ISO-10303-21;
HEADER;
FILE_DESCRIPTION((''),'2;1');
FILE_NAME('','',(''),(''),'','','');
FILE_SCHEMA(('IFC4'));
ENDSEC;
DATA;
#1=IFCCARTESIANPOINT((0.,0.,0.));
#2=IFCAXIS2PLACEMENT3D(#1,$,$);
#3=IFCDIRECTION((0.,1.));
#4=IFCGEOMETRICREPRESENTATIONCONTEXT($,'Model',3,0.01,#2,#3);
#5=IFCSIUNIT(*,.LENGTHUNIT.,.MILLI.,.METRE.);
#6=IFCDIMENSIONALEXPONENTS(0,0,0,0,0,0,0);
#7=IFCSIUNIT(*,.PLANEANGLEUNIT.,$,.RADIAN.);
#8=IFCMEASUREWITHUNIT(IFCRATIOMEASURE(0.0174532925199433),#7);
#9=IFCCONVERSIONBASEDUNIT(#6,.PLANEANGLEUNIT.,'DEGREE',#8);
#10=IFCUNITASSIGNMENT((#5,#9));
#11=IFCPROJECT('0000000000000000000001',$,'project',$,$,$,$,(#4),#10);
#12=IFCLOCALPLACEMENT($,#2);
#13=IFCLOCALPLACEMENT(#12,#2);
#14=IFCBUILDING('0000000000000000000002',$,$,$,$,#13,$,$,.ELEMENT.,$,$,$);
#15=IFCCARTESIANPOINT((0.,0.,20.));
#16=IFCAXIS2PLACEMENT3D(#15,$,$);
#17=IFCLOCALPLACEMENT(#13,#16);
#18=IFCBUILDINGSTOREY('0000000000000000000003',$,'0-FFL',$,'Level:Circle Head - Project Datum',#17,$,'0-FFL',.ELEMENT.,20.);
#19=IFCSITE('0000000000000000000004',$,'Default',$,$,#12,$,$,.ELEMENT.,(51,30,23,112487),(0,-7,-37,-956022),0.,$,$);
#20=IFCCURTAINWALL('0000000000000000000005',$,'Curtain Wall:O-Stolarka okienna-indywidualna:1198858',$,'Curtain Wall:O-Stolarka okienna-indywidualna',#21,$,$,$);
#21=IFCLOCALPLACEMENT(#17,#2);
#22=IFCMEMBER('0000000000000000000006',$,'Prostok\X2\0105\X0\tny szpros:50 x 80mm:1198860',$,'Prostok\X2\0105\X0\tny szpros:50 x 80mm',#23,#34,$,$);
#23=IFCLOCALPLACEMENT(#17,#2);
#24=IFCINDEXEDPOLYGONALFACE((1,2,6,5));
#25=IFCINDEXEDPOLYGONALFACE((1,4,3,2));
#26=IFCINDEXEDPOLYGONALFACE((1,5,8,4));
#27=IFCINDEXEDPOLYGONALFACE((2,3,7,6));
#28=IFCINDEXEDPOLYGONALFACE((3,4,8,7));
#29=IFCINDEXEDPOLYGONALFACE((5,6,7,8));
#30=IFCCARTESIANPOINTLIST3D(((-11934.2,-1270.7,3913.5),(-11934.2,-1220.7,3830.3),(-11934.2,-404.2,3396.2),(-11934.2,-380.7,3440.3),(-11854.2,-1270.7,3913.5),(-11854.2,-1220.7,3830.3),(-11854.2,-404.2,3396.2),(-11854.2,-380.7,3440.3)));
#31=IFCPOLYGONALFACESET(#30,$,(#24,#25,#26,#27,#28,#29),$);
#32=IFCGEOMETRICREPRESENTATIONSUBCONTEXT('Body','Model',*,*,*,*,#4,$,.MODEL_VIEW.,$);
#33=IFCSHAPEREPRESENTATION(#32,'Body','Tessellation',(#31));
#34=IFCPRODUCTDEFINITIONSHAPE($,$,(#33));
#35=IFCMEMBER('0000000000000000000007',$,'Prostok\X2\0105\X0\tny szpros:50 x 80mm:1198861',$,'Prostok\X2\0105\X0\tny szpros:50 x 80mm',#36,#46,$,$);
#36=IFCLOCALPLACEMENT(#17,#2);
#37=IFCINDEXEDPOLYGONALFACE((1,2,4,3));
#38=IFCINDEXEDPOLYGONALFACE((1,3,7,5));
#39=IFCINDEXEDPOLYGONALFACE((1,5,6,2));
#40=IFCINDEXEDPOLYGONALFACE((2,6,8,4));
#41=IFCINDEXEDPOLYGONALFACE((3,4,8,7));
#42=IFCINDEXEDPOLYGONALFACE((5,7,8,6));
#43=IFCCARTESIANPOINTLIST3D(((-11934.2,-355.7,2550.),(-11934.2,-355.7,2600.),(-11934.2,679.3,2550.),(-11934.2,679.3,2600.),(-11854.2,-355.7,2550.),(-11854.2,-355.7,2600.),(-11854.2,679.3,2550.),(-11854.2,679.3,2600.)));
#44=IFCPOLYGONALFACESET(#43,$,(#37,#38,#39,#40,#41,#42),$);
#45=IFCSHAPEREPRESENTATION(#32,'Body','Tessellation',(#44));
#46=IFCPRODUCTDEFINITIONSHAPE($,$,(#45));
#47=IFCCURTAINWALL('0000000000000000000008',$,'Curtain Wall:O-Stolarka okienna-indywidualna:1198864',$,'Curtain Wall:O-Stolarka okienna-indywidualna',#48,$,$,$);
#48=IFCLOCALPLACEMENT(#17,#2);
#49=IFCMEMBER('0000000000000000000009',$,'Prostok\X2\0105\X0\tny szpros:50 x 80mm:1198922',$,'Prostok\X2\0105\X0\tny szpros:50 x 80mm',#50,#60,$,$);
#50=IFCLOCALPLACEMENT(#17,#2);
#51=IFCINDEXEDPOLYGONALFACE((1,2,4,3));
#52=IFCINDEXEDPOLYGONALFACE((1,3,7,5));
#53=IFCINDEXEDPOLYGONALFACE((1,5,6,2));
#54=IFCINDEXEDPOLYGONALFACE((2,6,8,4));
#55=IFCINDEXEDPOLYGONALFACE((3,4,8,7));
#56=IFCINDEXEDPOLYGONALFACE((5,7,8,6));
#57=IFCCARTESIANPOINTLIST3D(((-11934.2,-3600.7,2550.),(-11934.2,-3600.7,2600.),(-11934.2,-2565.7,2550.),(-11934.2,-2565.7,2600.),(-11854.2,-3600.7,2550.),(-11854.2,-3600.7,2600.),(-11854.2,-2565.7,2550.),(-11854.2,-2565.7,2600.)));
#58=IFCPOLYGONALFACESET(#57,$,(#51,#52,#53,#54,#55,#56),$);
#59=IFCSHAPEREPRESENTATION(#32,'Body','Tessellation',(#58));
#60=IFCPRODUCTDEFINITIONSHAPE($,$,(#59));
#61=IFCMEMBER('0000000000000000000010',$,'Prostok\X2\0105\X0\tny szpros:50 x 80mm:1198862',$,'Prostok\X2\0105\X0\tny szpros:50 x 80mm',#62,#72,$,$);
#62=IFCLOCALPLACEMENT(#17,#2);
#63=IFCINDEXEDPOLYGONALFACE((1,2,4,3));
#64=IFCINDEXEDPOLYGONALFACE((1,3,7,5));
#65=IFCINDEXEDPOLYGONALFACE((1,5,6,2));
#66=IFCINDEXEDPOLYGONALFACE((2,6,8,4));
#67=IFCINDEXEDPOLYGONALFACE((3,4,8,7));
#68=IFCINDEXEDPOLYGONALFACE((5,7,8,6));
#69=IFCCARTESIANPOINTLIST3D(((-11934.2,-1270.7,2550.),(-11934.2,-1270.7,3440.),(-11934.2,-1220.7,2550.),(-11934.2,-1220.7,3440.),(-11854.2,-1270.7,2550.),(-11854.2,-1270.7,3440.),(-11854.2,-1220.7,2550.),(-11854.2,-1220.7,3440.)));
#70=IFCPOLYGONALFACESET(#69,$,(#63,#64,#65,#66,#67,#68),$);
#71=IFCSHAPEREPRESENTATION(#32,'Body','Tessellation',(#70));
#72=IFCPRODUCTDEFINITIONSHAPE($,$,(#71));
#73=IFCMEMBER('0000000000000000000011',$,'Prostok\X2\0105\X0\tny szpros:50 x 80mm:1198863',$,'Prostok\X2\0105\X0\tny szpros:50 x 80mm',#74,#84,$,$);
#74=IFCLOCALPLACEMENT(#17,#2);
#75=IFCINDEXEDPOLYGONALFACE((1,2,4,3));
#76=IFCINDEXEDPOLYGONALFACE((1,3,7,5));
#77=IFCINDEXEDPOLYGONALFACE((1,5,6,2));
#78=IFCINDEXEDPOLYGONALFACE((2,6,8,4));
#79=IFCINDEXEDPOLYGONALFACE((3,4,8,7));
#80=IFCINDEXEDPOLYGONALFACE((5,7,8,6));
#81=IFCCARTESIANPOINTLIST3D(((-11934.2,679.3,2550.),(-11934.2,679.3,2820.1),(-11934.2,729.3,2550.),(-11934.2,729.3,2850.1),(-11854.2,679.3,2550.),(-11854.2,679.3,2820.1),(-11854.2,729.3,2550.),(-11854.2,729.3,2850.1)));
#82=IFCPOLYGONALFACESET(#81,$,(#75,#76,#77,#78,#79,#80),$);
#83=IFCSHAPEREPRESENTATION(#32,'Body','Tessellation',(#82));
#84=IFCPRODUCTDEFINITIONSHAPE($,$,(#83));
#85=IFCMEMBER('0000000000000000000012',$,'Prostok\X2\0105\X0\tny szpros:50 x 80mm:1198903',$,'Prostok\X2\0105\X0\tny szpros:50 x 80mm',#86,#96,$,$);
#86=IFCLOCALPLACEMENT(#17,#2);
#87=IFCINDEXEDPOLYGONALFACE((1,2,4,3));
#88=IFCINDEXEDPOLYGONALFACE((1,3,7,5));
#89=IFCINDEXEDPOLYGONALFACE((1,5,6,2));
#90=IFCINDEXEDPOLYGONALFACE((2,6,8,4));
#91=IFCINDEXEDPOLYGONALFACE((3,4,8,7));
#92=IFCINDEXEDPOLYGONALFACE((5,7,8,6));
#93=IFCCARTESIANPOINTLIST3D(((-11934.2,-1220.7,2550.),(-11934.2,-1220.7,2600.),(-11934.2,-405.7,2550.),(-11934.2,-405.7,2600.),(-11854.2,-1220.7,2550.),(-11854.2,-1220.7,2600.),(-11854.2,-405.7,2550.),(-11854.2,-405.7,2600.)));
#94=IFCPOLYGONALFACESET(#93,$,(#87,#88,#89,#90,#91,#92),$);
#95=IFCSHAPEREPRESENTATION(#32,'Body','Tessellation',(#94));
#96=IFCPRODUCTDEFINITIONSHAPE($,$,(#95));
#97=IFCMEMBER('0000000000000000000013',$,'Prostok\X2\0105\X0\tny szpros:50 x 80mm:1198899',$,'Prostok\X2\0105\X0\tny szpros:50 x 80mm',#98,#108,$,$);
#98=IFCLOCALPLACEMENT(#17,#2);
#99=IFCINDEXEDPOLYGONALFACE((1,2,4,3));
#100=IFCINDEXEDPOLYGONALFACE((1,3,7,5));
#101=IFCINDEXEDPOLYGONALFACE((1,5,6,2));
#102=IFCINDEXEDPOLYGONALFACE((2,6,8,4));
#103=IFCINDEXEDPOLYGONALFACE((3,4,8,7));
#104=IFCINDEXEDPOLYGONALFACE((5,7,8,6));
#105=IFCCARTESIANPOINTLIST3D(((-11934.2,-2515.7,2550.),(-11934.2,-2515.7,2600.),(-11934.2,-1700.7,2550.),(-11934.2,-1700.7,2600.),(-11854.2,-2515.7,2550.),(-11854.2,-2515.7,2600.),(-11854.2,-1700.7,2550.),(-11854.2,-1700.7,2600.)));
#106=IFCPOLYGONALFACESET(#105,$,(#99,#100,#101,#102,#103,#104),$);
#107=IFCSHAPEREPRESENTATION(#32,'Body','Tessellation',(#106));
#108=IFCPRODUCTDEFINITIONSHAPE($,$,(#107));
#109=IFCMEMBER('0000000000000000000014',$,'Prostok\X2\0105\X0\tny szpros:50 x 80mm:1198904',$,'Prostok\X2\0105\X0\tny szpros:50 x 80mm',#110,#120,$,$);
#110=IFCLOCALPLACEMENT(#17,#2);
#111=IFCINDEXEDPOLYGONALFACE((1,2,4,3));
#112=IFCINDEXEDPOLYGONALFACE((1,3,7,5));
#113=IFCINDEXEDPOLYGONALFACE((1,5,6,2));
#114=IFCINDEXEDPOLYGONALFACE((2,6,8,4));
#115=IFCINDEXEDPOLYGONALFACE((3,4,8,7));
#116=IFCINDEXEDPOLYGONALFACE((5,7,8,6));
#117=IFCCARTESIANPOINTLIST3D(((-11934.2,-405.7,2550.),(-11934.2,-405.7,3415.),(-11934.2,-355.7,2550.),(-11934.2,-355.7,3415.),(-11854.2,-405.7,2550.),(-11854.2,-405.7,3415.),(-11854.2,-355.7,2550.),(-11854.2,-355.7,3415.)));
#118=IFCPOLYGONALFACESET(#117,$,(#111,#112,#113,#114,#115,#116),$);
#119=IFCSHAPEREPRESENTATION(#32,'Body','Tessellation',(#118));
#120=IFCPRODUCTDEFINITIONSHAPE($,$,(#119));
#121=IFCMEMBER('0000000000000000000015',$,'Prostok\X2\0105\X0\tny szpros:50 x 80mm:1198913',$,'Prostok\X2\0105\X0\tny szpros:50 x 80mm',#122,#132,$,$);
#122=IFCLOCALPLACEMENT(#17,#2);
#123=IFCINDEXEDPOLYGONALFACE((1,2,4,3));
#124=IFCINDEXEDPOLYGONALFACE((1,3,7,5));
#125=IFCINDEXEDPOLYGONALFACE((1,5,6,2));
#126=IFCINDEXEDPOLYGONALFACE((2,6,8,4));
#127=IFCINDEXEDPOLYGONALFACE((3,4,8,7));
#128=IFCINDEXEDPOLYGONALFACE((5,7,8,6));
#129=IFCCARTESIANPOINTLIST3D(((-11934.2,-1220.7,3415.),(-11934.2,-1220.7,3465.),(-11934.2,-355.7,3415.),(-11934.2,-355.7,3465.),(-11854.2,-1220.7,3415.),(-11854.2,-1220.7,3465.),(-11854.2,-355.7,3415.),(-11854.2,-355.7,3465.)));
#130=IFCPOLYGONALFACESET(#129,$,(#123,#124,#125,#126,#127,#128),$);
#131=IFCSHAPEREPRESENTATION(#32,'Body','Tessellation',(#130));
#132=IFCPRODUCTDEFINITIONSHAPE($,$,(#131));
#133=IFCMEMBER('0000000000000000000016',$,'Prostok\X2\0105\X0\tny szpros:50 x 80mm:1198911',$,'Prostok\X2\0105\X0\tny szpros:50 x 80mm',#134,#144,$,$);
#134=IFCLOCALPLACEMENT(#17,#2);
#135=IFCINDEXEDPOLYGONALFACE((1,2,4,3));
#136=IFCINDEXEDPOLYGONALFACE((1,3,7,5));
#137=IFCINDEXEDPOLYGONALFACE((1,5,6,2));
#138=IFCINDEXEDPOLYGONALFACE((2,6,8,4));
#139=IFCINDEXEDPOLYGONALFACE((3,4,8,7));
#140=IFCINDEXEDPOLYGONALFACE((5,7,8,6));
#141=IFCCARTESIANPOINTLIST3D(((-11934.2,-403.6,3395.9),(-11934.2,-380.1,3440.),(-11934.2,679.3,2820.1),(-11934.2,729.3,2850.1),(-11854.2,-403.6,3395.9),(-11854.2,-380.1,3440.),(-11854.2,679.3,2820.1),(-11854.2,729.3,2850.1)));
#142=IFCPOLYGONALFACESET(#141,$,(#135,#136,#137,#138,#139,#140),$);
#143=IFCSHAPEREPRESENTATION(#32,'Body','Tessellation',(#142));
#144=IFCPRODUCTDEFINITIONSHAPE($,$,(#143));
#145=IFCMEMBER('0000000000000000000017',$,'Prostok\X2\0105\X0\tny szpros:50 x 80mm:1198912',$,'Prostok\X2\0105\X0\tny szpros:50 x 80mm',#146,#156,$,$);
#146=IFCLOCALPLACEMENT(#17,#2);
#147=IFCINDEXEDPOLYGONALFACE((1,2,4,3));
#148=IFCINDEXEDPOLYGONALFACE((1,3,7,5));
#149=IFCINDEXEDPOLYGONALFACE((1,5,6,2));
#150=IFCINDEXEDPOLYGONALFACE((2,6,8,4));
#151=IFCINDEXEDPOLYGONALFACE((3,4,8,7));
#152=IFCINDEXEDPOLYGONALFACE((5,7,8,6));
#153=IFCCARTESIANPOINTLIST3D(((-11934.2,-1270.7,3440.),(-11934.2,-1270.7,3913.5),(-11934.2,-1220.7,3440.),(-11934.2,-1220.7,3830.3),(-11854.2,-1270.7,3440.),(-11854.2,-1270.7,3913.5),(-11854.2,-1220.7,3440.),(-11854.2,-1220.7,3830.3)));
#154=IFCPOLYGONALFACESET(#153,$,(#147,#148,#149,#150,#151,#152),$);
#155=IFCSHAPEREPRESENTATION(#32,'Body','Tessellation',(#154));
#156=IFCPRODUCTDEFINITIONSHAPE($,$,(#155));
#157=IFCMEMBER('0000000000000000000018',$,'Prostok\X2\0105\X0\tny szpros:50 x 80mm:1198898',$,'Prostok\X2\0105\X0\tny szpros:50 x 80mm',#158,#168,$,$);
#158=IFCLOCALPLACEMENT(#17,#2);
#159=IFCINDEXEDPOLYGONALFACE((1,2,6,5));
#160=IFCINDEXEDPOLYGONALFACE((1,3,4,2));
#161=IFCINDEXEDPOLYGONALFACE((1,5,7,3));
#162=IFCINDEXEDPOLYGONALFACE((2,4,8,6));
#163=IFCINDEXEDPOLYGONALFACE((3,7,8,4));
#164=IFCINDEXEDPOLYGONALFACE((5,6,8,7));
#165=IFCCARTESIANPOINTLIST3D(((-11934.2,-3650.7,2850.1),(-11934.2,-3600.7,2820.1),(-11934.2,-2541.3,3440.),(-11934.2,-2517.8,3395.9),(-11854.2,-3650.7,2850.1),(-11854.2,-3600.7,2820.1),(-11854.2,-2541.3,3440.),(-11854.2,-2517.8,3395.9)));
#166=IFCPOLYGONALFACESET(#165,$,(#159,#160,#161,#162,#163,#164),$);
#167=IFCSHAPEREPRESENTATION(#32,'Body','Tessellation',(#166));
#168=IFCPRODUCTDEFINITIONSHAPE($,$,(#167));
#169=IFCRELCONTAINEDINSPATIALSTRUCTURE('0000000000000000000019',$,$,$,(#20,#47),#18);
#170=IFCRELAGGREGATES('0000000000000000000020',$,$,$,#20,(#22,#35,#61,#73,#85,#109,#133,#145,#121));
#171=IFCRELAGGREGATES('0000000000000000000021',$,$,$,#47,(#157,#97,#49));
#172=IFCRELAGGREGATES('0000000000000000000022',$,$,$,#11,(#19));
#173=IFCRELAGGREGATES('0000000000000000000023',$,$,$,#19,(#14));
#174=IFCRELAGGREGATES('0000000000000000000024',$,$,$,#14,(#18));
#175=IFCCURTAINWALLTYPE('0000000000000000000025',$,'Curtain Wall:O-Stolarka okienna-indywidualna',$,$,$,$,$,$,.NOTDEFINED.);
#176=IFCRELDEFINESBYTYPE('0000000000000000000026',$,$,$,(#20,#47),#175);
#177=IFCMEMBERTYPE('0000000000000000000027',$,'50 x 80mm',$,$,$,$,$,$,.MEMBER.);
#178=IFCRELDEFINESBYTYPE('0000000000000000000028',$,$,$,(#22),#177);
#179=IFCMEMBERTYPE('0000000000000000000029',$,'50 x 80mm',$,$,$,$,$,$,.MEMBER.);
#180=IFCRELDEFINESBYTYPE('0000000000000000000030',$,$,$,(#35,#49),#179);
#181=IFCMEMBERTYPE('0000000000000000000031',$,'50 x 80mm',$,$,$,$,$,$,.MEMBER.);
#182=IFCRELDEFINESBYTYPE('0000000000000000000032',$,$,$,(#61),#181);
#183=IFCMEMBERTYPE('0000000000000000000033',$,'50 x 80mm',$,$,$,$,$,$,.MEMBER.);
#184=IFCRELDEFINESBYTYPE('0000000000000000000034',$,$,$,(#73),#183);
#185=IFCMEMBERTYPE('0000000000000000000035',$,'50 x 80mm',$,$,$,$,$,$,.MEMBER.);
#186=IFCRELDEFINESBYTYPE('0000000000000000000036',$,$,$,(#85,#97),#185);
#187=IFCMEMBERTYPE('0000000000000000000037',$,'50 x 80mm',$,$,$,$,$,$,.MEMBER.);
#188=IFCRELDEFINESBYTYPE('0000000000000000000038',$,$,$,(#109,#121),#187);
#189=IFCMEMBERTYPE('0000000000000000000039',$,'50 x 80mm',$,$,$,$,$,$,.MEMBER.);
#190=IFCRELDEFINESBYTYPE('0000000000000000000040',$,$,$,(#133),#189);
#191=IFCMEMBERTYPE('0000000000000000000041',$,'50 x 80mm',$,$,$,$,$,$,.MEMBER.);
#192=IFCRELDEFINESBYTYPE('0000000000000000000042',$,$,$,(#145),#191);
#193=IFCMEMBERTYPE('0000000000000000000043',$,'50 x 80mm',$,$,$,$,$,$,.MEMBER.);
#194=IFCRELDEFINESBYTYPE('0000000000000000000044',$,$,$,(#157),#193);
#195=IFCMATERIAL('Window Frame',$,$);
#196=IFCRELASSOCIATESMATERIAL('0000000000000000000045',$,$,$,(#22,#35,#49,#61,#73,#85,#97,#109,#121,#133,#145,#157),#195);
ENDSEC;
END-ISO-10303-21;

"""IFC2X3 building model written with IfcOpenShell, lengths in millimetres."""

from ifc_helpers import new_model, entity, si_unit, converted_unit, direction, frame, origin, origin_2d_with_axis, place, context, subcontext, project, spatial, rectangle, extrude, clip, halfspace, source, transform, mapped, material, type_object, type_shapes, element, aggregate, save


model = new_model("IFC2X3")

# Units and contexts
model_context = context("Model", 3, precision=0.01, world=origin(), true_north=direction((0.0, 1.0)))
body_context = subcontext(model_context, "Body", "Model", "MODEL_VIEW")
ifc_project = project(units=[si_unit("LENGTHUNIT", "METRE", prefix="MILLI"), converted_unit("PLANEANGLEUNIT", "DEGREE", entity("IfcRatioMeasure", 0.0174532925199433), si_unit("PLANEANGLEUNIT", "RADIAN"), dimensions=[0, 0, 0, 0, 0, 0, 0])], contexts=[model_context])

# Site, building, storey
site_placement = place(None, origin())
site = spatial("IfcSite", under=ifc_project, at=site_placement, Name="Default", CompositionType="ELEMENT", RefLatitude=(51, 30, 23, 112487), RefLongitude=(0, -7, -37, -956022), RefElevation=0.0)
building_placement = place(site_placement, origin())
building = spatial("IfcBuilding", under=site, at=building_placement, CompositionType="ELEMENT")
storey_placement = place(building_placement, frame((0.0, 0.0, 20.0)))
storey = spatial("IfcBuildingStorey", under=building, at=storey_placement, Name="0-FFL", ObjectType="Level:Circle Head - Project Datum", LongName="0-FFL", CompositionType="ELEMENT", Elevation=20.0)

# Curtain wall, members
curtain_wall_type = type_object("IfcCurtainWallType", Name="Curtain Wall:O-Stolarka okienna-indywidualna", PredefinedType="NOTDEFINED")
curtain_wall_1_placement = place(storey_placement, frame((0.0, 0.0, -20.0)))
curtain_wall_1 = element("IfcCurtainWall", 1, at=curtain_wall_1_placement, inside=storey, type_object=curtain_wall_type, Name="Curtain Wall:O-Stolarka okienna-indywidualna:1198858", ObjectType="Curtain Wall:O-Stolarka okienna-indywidualna")
ifc_material_1 = material(Name="Window Frame")
member_type_1 = type_object("IfcMemberType", Name="50 x 80mm", PredefinedType="MEMBER")
shared_shape_1 = source(origin(), body_context, "Body", "Clipping", [
    clip(extrude(rectangle(XDim=80.0, YDim=50.0, at=origin_2d_with_axis()), frame((-25.0, 0.0, -1008.0), z_axis=(0.0, 0.0, 1.0), x_axis=(0.0, -1.0, 0.0)), (0.0, 0.0, 1.0), 1008.0), halfspace(frame((0.0, -304.8, 0.0), z_axis=(-0.857167, 0.0, 0.515038), x_axis=(-0.515038, 0.0, -0.857167)), False)),
])
type_shapes(member_type_1, [shared_shape_1])
placement = place(building_placement, origin())
member_1_placement = place(placement, frame((-11894.2, -1270.7, 3933.5), z_axis=(0.0, -0.882948, 0.469472), x_axis=(0.0, 0.469472, 0.882948)))
member_1 = element("IfcMember", 2, at=member_1_placement, type_object=member_type_1, material=ifc_material_1, Name="Prostokątny szpros:50 x 80mm:1198860", ObjectType="Prostokątny szpros:50 x 80mm", context=body_context, shape_type="MappedRepresentation", body=[
    mapped(shared_shape_1, transform((0.0, 0.0, 0.0), scale=1.0)),
])
member_type_2 = type_object("IfcMemberType", Name="50 x 80mm", PredefinedType="MEMBER")
shared_shape_2 = source(origin(), body_context, "Body", "SweptSolid", [
    extrude(rectangle(XDim=80.0, YDim=50.0, at=origin_2d_with_axis()), frame((-25.0, 0.0, -1035.0), z_axis=(0.0, 0.0, 1.0), x_axis=(0.0, -1.0, 0.0)), (0.0, 0.0, 1.0), 1035.0),
])
type_shapes(member_type_2, [shared_shape_2])
member_2_placement = place(placement, frame((-11894.2, 679.3, 2570.0), z_axis=(0.0, 1.0, 0.0), x_axis=(0.0, 0.0, -1.0)))
member_2 = element("IfcMember", 3, at=member_2_placement, type_object=member_type_2, material=ifc_material_1, Name="Prostokątny szpros:50 x 80mm:1198861", ObjectType="Prostokątny szpros:50 x 80mm", context=body_context, shape_type="MappedRepresentation", body=[
    mapped(shared_shape_2, transform((0.0, 0.0, 0.0), scale=1.0)),
])

# Curtain wall, member
curtain_wall_2_placement = place(storey_placement, frame((0.0, 0.0, -20.0)))
curtain_wall_2 = element("IfcCurtainWall", 4, at=curtain_wall_2_placement, inside=storey, type_object=curtain_wall_type, Name="Curtain Wall:O-Stolarka okienna-indywidualna:1198864", ObjectType="Curtain Wall:O-Stolarka okienna-indywidualna")
member_3_placement = place(placement, frame((-11894.2, -2565.7, 2570.0), z_axis=(0.0, 1.0, 0.0), x_axis=(0.0, 0.0, -1.0)))
member_3 = element("IfcMember", 5, at=member_3_placement, type_object=member_type_2, material=ifc_material_1, Name="Prostokątny szpros:50 x 80mm:1198922", ObjectType="Prostokątny szpros:50 x 80mm", context=body_context, shape_type="MappedRepresentation", body=[
    mapped(shared_shape_2, transform((0.0, 0.0, 0.0), scale=1.0)),
])

# Members
member_type_3 = type_object("IfcMemberType", Name="50 x 80mm", PredefinedType="MEMBER")
shared_shape_3 = source(origin(), body_context, "Body", "SweptSolid", [
    extrude(rectangle(XDim=80.0, YDim=50.0, at=origin_2d_with_axis()), frame((-25.0, 0.0, -890.0), z_axis=(0.0, 0.0, 1.0), x_axis=(0.0, -1.0, 0.0)), (0.0, 0.0, 1.0), 890.0),
])
type_shapes(member_type_3, [shared_shape_3])
member_4_placement = place(placement, frame((-11894.2, -1270.7, 2570.0), z_axis=(0.0, 0.0, -1.0), x_axis=(0.0, -1.0, 0.0)))
member_4 = element("IfcMember", 6, at=member_4_placement, type_object=member_type_3, material=ifc_material_1, Name="Prostokątny szpros:50 x 80mm:1198862", ObjectType="Prostokątny szpros:50 x 80mm", context=body_context, shape_type="MappedRepresentation", body=[
    mapped(shared_shape_3, transform((0.0, 0.0, 0.0), scale=1.0)),
])
member_type_4 = type_object("IfcMemberType", Name="50 x 80mm", PredefinedType="MEMBER")
shared_shape_4 = source(origin(), body_context, "Body", "Clipping", [
    clip(extrude(rectangle(XDim=80.0, YDim=50.0, at=origin_2d_with_axis()), frame((-25.0, 0.0, -300.1), z_axis=(0.0, 0.0, 1.0), x_axis=(0.0, -1.0, 0.0)), (0.0, 0.0, 1.0), 300.1), halfspace(frame((0.0, -304.8, 0.0), z_axis=(-0.515038, 0.0, 0.857167), x_axis=(-0.857167, 0.0, -0.515038)), False)),
])
type_shapes(member_type_4, [shared_shape_4])
member_5_placement = place(placement, frame((-11894.2, 729.3, 2870.1), z_axis=(0.0, 0.0, 1.0), x_axis=(0.0, 1.0, 0.0)))
member_5 = element("IfcMember", 7, at=member_5_placement, type_object=member_type_4, material=ifc_material_1, Name="Prostokątny szpros:50 x 80mm:1198863", ObjectType="Prostokątny szpros:50 x 80mm", context=body_context, shape_type="MappedRepresentation", body=[
    mapped(shared_shape_4, transform((0.0, 0.0, 0.0), scale=1.0)),
])
member_type_5 = type_object("IfcMemberType", Name="50 x 80mm", PredefinedType="MEMBER")
shared_shape_5 = source(origin(), body_context, "Body", "SweptSolid", [
    extrude(rectangle(XDim=80.0, YDim=50.0, at=origin_2d_with_axis()), frame((-25.0, 0.0, -815.0), z_axis=(0.0, 0.0, 1.0), x_axis=(0.0, -1.0, 0.0)), (0.0, 0.0, 1.0), 815.0),
])
type_shapes(member_type_5, [shared_shape_5])
member_6_placement = place(placement, frame((-11894.2, -405.7, 2570.0), z_axis=(0.0, 1.0, 0.0), x_axis=(0.0, 0.0, -1.0)))
member_6 = element("IfcMember", 8, at=member_6_placement, type_object=member_type_5, material=ifc_material_1, Name="Prostokątny szpros:50 x 80mm:1198903", ObjectType="Prostokątny szpros:50 x 80mm", context=body_context, shape_type="MappedRepresentation", body=[
    mapped(shared_shape_5, transform((0.0, 0.0, 0.0), scale=1.0)),
])
member_7_placement = place(placement, frame((-11894.2, -1700.7, 2570.0), z_axis=(0.0, 1.0, 0.0), x_axis=(0.0, 0.0, -1.0)))
member_7 = element("IfcMember", 9, at=member_7_placement, type_object=member_type_5, material=ifc_material_1, Name="Prostokątny szpros:50 x 80mm:1198899", ObjectType="Prostokątny szpros:50 x 80mm", context=body_context, shape_type="MappedRepresentation", body=[
    mapped(shared_shape_5, transform((0.0, 0.0, 0.0), scale=1.0)),
])
member_type_6 = type_object("IfcMemberType", Name="50 x 80mm", PredefinedType="MEMBER")
shared_shape_6 = source(origin(), body_context, "Body", "SweptSolid", [
    extrude(rectangle(XDim=80.0, YDim=50.0, at=origin_2d_with_axis()), frame((0.0, 0.0, -865.0), z_axis=(0.0, 0.0, 1.0), x_axis=(0.0, -1.0, 0.0)), (0.0, 0.0, 1.0), 865.0),
])
type_shapes(member_type_6, [shared_shape_6])
member_8_placement = place(placement, frame((-11894.2, -380.7, 2570.0), z_axis=(0.0, 0.0, -1.0), x_axis=(0.0, -1.0, 0.0)))
member_8 = element("IfcMember", 10, at=member_8_placement, type_object=member_type_6, material=ifc_material_1, Name="Prostokątny szpros:50 x 80mm:1198904", ObjectType="Prostokątny szpros:50 x 80mm", context=body_context, shape_type="MappedRepresentation", body=[
    mapped(shared_shape_6, transform((0.0, 0.0, 0.0), scale=1.0)),
])
member_9_placement = place(placement, frame((-11894.2, -1220.7, 3460.0), z_axis=(0.0, -1.0, 0.0), x_axis=(0.0, 0.0, 1.0)))
member_9 = element("IfcMember", 11, at=member_9_placement, type_object=member_type_6, material=ifc_material_1, Name="Prostokątny szpros:50 x 80mm:1198913", ObjectType="Prostokątny szpros:50 x 80mm", context=body_context, shape_type="MappedRepresentation", body=[
    mapped(shared_shape_6, transform((0.0, 0.0, 0.0), scale=1.0)),
])
member_type_7 = type_object("IfcMemberType", Name="50 x 80mm", PredefinedType="MEMBER")
shared_shape_7 = source(origin(), body_context, "Body", "Clipping", [
    clip(extrude(rectangle(XDim=80.0, YDim=50.0, at=origin_2d_with_axis()), frame((-25.0, 0.0, -1256.5), z_axis=(0.0, 0.0, 1.0), x_axis=(0.0, -1.0, 0.0)), (0.0, 0.0, 1.0), 1256.5), halfspace(frame((0.0, -304.8, -1256.5), z_axis=(-0.515038, 0.0, -0.857167), x_axis=(-0.857167, 0.0, 0.515038)), False)),
])
type_shapes(member_type_7, [shared_shape_7])
member_10_placement = place(placement, frame((-11894.2, -380.1, 3460.0), z_axis=(0.0, -0.882948, 0.469472), x_axis=(0.0, 0.469472, 0.882948)))
member_10 = element("IfcMember", 12, at=member_10_placement, type_object=member_type_7, material=ifc_material_1, Name="Prostokątny szpros:50 x 80mm:1198911", ObjectType="Prostokątny szpros:50 x 80mm", context=body_context, shape_type="MappedRepresentation", body=[
    mapped(shared_shape_7, transform((0.0, 0.0, 0.0), scale=1.0)),
])
member_type_8 = type_object("IfcMemberType", Name="50 x 80mm", PredefinedType="MEMBER")
shared_shape_8 = source(origin(), body_context, "Body", "Clipping", [
    clip(extrude(rectangle(XDim=80.0, YDim=50.0, at=origin_2d_with_axis()), frame((-25.0, 0.0, -473.5), z_axis=(0.0, 0.0, 1.0), x_axis=(0.0, -1.0, 0.0)), (0.0, 0.0, 1.0), 473.5), halfspace(frame((0.0, -304.8, -473.5), z_axis=(-0.857167, 0.0, -0.515038), x_axis=(-0.515038, 0.0, 0.857167)), False)),
])
type_shapes(member_type_8, [shared_shape_8])
member_11_placement = place(placement, frame((-11894.2, -1270.7, 3460.0), z_axis=(0.0, 0.0, -1.0), x_axis=(0.0, -1.0, 0.0)))
member_11 = element("IfcMember", 13, at=member_11_placement, type_object=member_type_8, material=ifc_material_1, Name="Prostokątny szpros:50 x 80mm:1198912", ObjectType="Prostokątny szpros:50 x 80mm", context=body_context, shape_type="MappedRepresentation", body=[
    mapped(shared_shape_8, transform((0.0, 0.0, 0.0), scale=1.0)),
])
member_type_9 = type_object("IfcMemberType", Name="50 x 80mm", PredefinedType="MEMBER")
shared_shape_9 = source(origin(), body_context, "Body", "Clipping", [
    clip(extrude(rectangle(XDim=80.0, YDim=50.0, at=origin_2d_with_axis()), frame((-25.0, 0.0, -1256.5), z_axis=(0.0, 0.0, 1.0), x_axis=(0.0, -1.0, 0.0)), (0.0, 0.0, 1.0), 1256.5), halfspace(frame((0.0, -304.8, 0.0), z_axis=(-0.515038, 0.0, 0.857167), x_axis=(-0.857167, 0.0, -0.515038)), False)),
])
type_shapes(member_type_9, [shared_shape_9])
member_12_placement = place(placement, frame((-11894.2, -3650.7, 2870.1), z_axis=(0.0, -0.882948, -0.469472), x_axis=(0.0, -0.469472, 0.882948)))
member_12 = element("IfcMember", 14, at=member_12_placement, type_object=member_type_9, material=ifc_material_1, Name="Prostokątny szpros:50 x 80mm:1198898", ObjectType="Prostokątny szpros:50 x 80mm", context=body_context, shape_type="MappedRepresentation", body=[
    mapped(shared_shape_9, transform((0.0, 0.0, 0.0), scale=1.0)),
])

aggregate(curtain_wall_1, [member_1, member_2, member_4, member_5, member_6, member_8, member_10, member_11, member_9])
aggregate(curtain_wall_2, [member_12, member_7, member_3])

save(model, "model.ifc")
